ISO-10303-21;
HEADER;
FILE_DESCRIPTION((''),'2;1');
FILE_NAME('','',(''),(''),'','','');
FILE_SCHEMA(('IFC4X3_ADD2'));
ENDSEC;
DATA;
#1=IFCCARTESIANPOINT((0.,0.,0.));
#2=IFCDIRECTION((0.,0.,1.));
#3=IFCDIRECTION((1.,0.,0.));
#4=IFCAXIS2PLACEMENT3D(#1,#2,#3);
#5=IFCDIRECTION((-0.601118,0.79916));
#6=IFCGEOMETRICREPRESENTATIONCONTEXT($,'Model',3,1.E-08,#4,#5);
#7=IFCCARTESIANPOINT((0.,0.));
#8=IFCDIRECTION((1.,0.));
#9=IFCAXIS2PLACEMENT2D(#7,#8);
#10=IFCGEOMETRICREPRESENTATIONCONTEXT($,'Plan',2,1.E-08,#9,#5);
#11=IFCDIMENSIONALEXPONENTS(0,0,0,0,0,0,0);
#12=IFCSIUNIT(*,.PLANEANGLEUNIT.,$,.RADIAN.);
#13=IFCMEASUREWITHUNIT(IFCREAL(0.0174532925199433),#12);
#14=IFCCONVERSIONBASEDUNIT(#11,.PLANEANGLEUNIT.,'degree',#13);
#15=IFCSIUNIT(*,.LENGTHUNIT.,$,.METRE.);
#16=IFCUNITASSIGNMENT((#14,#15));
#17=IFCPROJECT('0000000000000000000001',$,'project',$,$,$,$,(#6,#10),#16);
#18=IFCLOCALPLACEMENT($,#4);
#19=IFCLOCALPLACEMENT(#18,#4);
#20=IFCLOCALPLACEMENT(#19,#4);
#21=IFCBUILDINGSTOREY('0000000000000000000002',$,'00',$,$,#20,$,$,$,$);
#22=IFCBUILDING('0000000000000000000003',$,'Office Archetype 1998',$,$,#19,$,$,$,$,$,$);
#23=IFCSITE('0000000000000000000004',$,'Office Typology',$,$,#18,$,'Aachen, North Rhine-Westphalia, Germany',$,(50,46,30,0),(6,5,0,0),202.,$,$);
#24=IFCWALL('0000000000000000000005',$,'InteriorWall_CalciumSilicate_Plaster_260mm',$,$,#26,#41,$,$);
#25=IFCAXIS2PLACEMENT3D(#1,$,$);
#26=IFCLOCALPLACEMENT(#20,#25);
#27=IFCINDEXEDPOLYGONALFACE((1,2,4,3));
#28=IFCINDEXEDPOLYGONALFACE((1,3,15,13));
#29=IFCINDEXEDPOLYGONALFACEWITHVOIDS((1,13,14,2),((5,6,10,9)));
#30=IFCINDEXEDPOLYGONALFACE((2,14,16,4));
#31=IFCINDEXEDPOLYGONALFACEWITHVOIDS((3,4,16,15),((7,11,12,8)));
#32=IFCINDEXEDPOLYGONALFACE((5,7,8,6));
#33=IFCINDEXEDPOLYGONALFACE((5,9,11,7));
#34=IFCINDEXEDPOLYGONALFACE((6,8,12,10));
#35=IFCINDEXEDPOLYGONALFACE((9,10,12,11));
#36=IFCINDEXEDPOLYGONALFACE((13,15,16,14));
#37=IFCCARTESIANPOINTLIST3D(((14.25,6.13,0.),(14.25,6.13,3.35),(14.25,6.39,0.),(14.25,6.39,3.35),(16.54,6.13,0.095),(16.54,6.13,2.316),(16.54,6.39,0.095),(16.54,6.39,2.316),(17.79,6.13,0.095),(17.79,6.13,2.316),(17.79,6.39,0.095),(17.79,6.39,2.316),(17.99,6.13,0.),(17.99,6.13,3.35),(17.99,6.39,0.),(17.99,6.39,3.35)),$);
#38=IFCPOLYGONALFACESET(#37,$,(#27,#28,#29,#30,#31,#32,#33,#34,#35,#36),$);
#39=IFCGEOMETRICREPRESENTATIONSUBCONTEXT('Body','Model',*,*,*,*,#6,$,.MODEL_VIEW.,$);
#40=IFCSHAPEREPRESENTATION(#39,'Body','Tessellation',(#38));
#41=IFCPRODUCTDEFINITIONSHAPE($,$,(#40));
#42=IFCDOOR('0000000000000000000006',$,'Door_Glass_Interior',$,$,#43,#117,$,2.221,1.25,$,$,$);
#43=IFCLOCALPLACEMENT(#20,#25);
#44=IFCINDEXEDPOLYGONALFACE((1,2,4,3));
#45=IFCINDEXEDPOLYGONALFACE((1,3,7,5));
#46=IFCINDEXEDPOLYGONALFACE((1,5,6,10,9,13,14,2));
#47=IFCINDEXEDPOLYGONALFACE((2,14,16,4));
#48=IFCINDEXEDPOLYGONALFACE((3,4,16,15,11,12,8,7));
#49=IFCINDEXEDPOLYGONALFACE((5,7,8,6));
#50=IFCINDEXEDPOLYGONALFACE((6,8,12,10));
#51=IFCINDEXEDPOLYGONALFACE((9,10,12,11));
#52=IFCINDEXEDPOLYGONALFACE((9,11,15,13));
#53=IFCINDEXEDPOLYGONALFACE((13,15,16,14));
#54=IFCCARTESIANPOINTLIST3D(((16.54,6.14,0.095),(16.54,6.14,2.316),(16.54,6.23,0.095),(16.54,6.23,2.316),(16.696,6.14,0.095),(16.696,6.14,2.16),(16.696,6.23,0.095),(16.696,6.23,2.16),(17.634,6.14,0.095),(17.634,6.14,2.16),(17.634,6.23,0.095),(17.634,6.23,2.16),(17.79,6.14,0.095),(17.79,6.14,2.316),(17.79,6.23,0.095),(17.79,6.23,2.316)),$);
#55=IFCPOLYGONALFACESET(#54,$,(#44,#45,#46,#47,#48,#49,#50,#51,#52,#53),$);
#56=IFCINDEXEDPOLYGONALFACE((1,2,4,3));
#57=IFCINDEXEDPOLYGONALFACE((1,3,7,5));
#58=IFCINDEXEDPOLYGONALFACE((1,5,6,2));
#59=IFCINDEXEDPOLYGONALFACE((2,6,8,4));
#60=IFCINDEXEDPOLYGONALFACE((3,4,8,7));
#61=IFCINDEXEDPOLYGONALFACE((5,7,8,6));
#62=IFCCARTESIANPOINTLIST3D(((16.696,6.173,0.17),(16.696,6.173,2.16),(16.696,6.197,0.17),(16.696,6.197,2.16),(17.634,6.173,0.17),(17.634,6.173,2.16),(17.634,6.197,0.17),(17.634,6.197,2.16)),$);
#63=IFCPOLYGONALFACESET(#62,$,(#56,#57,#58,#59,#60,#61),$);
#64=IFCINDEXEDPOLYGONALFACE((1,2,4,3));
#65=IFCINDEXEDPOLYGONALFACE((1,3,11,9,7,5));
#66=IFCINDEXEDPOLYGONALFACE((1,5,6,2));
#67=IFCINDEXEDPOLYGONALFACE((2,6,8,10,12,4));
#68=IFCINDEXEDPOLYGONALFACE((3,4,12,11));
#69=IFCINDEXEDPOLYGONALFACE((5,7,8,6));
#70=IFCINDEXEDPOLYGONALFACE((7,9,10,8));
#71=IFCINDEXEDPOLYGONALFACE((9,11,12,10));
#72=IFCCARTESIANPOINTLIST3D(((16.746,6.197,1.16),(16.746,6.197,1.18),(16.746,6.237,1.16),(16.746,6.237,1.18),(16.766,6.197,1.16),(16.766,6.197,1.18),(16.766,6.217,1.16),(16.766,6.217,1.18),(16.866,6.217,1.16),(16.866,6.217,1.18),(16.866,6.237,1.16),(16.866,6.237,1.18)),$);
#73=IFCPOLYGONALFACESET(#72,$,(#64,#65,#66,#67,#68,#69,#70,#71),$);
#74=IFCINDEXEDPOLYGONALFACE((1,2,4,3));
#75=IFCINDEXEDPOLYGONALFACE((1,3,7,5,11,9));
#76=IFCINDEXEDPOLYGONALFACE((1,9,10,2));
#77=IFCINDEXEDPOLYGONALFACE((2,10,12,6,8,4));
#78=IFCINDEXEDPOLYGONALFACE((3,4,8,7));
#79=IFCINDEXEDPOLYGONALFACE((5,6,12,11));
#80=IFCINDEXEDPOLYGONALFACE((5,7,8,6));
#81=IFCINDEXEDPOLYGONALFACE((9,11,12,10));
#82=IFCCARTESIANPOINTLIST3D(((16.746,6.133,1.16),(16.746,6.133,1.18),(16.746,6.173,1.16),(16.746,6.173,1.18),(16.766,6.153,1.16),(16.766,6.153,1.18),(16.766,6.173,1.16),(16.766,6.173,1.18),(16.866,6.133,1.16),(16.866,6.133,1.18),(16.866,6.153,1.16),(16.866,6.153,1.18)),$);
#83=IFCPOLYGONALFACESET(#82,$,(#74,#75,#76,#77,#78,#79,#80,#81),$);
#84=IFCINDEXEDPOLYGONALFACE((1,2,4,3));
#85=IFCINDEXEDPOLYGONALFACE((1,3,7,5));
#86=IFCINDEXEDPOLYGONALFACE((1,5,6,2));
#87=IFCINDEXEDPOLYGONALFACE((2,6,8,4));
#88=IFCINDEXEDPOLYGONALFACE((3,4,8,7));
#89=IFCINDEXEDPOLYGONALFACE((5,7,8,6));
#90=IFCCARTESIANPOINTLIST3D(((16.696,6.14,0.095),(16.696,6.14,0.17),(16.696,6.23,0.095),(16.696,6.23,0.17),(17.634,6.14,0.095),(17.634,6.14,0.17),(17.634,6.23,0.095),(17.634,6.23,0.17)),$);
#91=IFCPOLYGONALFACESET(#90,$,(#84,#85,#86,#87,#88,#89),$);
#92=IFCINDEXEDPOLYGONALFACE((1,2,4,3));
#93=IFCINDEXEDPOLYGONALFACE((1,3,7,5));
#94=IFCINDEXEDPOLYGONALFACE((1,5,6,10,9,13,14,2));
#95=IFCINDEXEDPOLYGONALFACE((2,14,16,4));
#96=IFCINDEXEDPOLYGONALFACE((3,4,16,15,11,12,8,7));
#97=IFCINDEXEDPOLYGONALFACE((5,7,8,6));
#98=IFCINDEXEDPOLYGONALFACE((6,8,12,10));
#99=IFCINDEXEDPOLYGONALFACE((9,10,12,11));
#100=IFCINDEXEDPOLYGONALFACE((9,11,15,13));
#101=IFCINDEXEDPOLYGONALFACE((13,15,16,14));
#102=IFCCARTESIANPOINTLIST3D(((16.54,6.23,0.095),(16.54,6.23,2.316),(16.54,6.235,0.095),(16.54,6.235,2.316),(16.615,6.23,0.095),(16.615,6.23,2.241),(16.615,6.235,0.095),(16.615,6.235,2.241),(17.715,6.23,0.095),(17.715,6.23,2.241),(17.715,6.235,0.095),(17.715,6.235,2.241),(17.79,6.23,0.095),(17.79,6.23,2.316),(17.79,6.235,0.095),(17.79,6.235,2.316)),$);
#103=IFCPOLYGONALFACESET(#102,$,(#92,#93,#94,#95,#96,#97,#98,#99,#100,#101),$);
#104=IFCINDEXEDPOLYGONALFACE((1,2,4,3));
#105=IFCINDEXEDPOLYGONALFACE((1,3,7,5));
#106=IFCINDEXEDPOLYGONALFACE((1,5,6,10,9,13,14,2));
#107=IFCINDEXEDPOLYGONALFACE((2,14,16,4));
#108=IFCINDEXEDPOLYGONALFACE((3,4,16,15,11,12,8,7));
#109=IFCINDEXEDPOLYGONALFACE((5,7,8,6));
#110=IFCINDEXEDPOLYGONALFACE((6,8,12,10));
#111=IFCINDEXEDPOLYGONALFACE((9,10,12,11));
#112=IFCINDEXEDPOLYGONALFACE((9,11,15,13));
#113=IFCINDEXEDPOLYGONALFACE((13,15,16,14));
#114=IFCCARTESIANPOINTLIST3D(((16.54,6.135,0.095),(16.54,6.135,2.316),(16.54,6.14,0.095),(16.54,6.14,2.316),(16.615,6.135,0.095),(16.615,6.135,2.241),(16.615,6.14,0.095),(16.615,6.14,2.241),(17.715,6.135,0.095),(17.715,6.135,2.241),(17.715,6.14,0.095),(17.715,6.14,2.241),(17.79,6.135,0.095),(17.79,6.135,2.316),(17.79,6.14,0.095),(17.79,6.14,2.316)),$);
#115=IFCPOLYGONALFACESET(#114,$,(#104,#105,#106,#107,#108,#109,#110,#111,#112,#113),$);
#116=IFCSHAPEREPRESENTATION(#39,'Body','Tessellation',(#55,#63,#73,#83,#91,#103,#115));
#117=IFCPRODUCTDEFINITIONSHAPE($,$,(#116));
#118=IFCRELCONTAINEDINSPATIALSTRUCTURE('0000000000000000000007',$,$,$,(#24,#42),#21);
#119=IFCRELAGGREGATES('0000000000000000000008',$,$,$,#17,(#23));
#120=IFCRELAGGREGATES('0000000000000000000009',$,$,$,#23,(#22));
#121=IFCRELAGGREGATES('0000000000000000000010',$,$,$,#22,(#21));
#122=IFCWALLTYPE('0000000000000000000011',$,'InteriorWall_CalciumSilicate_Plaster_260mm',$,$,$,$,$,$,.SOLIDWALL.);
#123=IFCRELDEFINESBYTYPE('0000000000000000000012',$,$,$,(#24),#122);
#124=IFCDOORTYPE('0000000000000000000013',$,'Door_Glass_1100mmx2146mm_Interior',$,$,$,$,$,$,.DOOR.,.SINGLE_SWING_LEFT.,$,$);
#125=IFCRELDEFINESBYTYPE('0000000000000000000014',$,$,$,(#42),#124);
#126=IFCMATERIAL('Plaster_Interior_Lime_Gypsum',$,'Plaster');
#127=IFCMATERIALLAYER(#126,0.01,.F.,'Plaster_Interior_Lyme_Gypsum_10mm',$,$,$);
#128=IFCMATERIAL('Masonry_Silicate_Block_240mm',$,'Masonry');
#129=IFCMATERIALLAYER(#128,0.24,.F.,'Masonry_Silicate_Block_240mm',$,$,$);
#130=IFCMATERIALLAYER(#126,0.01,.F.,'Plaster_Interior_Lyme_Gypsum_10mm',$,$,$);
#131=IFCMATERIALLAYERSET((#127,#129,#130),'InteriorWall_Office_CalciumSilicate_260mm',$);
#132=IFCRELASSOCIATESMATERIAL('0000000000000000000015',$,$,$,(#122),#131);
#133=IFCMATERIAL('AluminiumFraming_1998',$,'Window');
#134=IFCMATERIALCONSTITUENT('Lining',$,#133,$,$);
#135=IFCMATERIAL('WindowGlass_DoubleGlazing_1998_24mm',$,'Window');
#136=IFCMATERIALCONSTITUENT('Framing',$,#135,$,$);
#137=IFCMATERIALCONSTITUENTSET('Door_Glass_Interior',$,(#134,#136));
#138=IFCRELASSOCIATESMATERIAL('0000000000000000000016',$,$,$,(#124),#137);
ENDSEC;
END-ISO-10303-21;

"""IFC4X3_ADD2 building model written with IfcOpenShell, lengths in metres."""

from ifc_helpers import new_model, entity, si_unit, converted_unit, direction, frame, origin_with_axes, origin_2d_with_axis, place, context, subcontext, project, spatial, line, indexed_curve, outline, extrude, source, transform, mapped, material, layer, layer_set, constituent, constituent_set, type_object, type_shapes, element, fill, save


model = new_model("IFC4X3_ADD2")

# Units and contexts
model_context = context("Model", 3, precision=1e-08, world=origin_with_axes(), true_north=direction((-0.601118, 0.79916)))
plan_context = context("Plan", 2, precision=1e-08, world=origin_2d_with_axis(), true_north=direction((-0.601118, 0.79916)))
body_context = subcontext(model_context, "Body", "Model", "MODEL_VIEW")
ifc_project = project(units=[converted_unit("PLANEANGLEUNIT", "degree", entity("IfcReal", 0.0174532925199433), si_unit("PLANEANGLEUNIT", "RADIAN"), dimensions=[0, 0, 0, 0, 0, 0, 0]), si_unit("LENGTHUNIT", "METRE")], contexts=[model_context, plan_context])

# Site, building, storey
site_placement = place(None, origin_with_axes())
site = spatial("IfcSite", under=ifc_project, at=site_placement, Name="Office Typology", LongName="Aachen, North Rhine-Westphalia, Germany", RefLatitude=(50, 46, 30, 0), RefLongitude=(6, 5, 0, 0), RefElevation=202.0)
building_placement = place(site_placement, origin_with_axes())
building = spatial("IfcBuilding", under=site, at=building_placement, Name="Office Archetype 1998")
storey_placement = place(building_placement, origin_with_axes())
storey = spatial("IfcBuildingStorey", under=building, at=storey_placement, Name="00")

# Shared definitions
ifc_material_1 = material(Name="Plaster_Interior_Lime_Gypsum", Category="Plaster")
ifc_layer_1 = layer(ifc_material_1, 0.01, ventilated=False, Name="Plaster_Interior_Lyme_Gypsum_10mm")
ifc_material_2 = material(Name="Masonry_Silicate_Block_240mm", Category="Masonry")
ifc_layer_2 = layer(ifc_material_2, 0.24, ventilated=False, Name="Masonry_Silicate_Block_240mm")
ifc_layer_3 = layer(ifc_material_1, 0.01, ventilated=False, Name="Plaster_Interior_Lyme_Gypsum_10mm")
ifc_layer_set = layer_set([ifc_layer_1, ifc_layer_2, ifc_layer_3], Name="InteriorWall_Office_CalciumSilicate_260mm")
wall_type = type_object("IfcWallType", Name="InteriorWall_CalciumSilicate_Plaster_260mm", PredefinedType="SOLIDWALL", material=ifc_layer_set)

# Wall, opening, door
wall_1_placement = place(storey_placement, frame((18.25, 6.39, 0.0), z_axis=(0.0, 0.0, 1.0), x_axis=(-1.0, 0.0, 0.0)))
wall_1 = element("IfcWall", 1, at=wall_1_placement, inside=storey, type_object=wall_type, Name="InteriorWall_CalciumSilicate_Plaster_260mm", context=body_context, shape_type="SweptSolid", body=[
    extrude(outline(indexed_curve([(0.26, 0.0), (0.26, 0.26), (4.0, 0.26), (4.0, 0.0), (0.26, 0.0)])), origin_with_axes(), (0.0, 0.0, 1.0), 3.35),
])
shared_shape_1 = source(origin_with_axes(), body_context, "Body", "SweptSolid", [
    extrude(outline(indexed_curve([(0.0, 2.221), (1.25, 2.221), (1.25, 0.0), (0.0, 0.0), (0.0, 2.221)])), frame((0.0, -0.16, 0.0), z_axis=(0.0, -1.0, 0.0), x_axis=(1.0, 0.0, 0.0)), (0.0, 0.0, -1.0), 0.26),
])
opening_1_placement = place(wall_1_placement, frame((0.46, 0.16, 0.095), z_axis=(0.0, 0.0, 1.0), x_axis=(1.0, 0.0, 0.0)))
opening_1 = element("IfcOpeningElement", 2, at=opening_1_placement, cuts=wall_1, PredefinedType="OPENING", context=body_context, shape_type="MappedRepresentation", body=[
    mapped(shared_shape_1, transform((0.0, 0.0, 0.0), x_axis=(1.0, 0.0, 0.0), y_axis=(0.0, 1.0, 0.0), z_axis=(0.0, 0.0, 1.0), scale=1.0)),
])
ifc_material_3 = material(Name="AluminiumFraming_1998", Category="Window")
ifc_constituent_1 = constituent(ifc_material_3, Name="Lining")
ifc_material_4 = material(Name="WindowGlass_DoubleGlazing_1998_24mm", Category="Window")
ifc_constituent_2 = constituent(ifc_material_4, Name="Framing")
ifc_constituent_set_1 = constituent_set(constituents=[ifc_constituent_1, ifc_constituent_2], Name="Door_Glass_Interior")
door_type_1 = type_object("IfcDoorType", Name="Door_Glass_1100mmx2146mm_Interior", OperationType="SINGLE_SWING_LEFT", PredefinedType="DOOR", material=ifc_constituent_set_1)
shared_shape_2 = source(origin_with_axes(), body_context, "Body", "SweptSolid", [
    extrude(outline(indexed_curve([(0.0, 0.0), (0.0, 2.221), (1.25, 2.221), (1.25, 0.0), (1.094, 0.0), (1.094, 2.065), (0.156, 2.065), (0.156, 0.0)], segments=[line(1, 2, 3, 4, 5, 6, 7, 8, 1)])), frame((0.0, 0.0, 0.0), z_axis=(0.0, -1.0, 0.0), x_axis=(1.0, 0.0, 0.0)), (0.0, 0.0, -1.0), 0.09),
    extrude(outline(indexed_curve([(0.0, 0.0), (0.938, 0.0), (0.938, 0.024), (0.0, 0.024)], segments=[line(1, 2, 3, 4, 1)])), frame((0.156, 0.033, 0.075), z_axis=(0.0, 0.0, 1.0), x_axis=(1.0, 0.0, 0.0)), (0.0, 0.0, 1.0), 1.99),
    extrude(outline(indexed_curve([(0.0, 0.0), (0.0, -0.04), (-0.12, -0.04), (-0.12, -0.02), (-0.02, -0.02), (-0.02, 0.0)], segments=[line(1, 2, 3, 4, 5, 6, 1)])), frame((1.044, 0.033, 1.065), z_axis=(0.0, 0.0, 1.0), x_axis=(1.0, 0.0, 0.0)), (0.0, 0.0, 1.0), 0.02),
    extrude(outline(indexed_curve([(0.0, 0.0), (0.0, 0.04), (-0.12, 0.04), (-0.12, 0.02), (-0.02, 0.02), (-0.02, 0.0)], segments=[line(1, 2, 3, 4, 5, 6, 1)])), frame((1.044, 0.057, 1.065), z_axis=(0.0, 0.0, 1.0), x_axis=(1.0, 0.0, 0.0)), (0.0, 0.0, 1.0), 0.02),
    extrude(outline(indexed_curve([(0.0, 0.0), (0.938, 0.0), (0.938, 0.09), (0.0, 0.09)], segments=[line(1, 2, 3, 4, 1)])), frame((0.156, 0.0, 0.0), z_axis=(0.0, 0.0, 1.0), x_axis=(1.0, 0.0, 0.0)), (0.0, 0.0, 1.0), 0.075),
    extrude(outline(indexed_curve([(0.0, 0.0), (0.0, 2.221), (1.25, 2.221), (1.25, 0.0), (1.175, 0.0), (1.175, 2.146), (0.075, 2.146), (0.075, 0.0)], segments=[line(1, 2, 3, 4, 5, 6, 7, 8, 1)])), frame((0.0, -0.005, 0.0), z_axis=(0.0, -1.0, 0.0), x_axis=(1.0, 0.0, 0.0)), (0.0, 0.0, -1.0), 0.005),
    extrude(outline(indexed_curve([(0.0, 0.0), (0.0, 2.221), (1.25, 2.221), (1.25, 0.0), (1.175, 0.0), (1.175, 2.146), (0.075, 2.146), (0.075, 0.0)], segments=[line(1, 2, 3, 4, 5, 6, 7, 8, 1)])), frame((0.0, 0.09, 0.0), z_axis=(0.0, -1.0, 0.0), x_axis=(1.0, 0.0, 0.0)), (0.0, 0.0, -1.0), 0.005),
])
type_shapes(door_type_1, [shared_shape_2])
door_1_placement = place(opening_1_placement, origin_with_axes())
door_1 = element("IfcDoor", 3, at=door_1_placement, inside=storey, type_object=door_type_1, Name="Door_Glass_Interior", OverallHeight=2.221, OverallWidth=1.25, context=body_context, shape_type="MappedRepresentation", body=[
    mapped(shared_shape_2, transform((0.0, 0.0, 0.0), x_axis=(1.0, 0.0, 0.0), y_axis=(0.0, 1.0, 0.0), z_axis=(0.0, 0.0, 1.0), scale=1.0)),
])
fill(opening_1, door_1)

save(model, "model.ifc")
